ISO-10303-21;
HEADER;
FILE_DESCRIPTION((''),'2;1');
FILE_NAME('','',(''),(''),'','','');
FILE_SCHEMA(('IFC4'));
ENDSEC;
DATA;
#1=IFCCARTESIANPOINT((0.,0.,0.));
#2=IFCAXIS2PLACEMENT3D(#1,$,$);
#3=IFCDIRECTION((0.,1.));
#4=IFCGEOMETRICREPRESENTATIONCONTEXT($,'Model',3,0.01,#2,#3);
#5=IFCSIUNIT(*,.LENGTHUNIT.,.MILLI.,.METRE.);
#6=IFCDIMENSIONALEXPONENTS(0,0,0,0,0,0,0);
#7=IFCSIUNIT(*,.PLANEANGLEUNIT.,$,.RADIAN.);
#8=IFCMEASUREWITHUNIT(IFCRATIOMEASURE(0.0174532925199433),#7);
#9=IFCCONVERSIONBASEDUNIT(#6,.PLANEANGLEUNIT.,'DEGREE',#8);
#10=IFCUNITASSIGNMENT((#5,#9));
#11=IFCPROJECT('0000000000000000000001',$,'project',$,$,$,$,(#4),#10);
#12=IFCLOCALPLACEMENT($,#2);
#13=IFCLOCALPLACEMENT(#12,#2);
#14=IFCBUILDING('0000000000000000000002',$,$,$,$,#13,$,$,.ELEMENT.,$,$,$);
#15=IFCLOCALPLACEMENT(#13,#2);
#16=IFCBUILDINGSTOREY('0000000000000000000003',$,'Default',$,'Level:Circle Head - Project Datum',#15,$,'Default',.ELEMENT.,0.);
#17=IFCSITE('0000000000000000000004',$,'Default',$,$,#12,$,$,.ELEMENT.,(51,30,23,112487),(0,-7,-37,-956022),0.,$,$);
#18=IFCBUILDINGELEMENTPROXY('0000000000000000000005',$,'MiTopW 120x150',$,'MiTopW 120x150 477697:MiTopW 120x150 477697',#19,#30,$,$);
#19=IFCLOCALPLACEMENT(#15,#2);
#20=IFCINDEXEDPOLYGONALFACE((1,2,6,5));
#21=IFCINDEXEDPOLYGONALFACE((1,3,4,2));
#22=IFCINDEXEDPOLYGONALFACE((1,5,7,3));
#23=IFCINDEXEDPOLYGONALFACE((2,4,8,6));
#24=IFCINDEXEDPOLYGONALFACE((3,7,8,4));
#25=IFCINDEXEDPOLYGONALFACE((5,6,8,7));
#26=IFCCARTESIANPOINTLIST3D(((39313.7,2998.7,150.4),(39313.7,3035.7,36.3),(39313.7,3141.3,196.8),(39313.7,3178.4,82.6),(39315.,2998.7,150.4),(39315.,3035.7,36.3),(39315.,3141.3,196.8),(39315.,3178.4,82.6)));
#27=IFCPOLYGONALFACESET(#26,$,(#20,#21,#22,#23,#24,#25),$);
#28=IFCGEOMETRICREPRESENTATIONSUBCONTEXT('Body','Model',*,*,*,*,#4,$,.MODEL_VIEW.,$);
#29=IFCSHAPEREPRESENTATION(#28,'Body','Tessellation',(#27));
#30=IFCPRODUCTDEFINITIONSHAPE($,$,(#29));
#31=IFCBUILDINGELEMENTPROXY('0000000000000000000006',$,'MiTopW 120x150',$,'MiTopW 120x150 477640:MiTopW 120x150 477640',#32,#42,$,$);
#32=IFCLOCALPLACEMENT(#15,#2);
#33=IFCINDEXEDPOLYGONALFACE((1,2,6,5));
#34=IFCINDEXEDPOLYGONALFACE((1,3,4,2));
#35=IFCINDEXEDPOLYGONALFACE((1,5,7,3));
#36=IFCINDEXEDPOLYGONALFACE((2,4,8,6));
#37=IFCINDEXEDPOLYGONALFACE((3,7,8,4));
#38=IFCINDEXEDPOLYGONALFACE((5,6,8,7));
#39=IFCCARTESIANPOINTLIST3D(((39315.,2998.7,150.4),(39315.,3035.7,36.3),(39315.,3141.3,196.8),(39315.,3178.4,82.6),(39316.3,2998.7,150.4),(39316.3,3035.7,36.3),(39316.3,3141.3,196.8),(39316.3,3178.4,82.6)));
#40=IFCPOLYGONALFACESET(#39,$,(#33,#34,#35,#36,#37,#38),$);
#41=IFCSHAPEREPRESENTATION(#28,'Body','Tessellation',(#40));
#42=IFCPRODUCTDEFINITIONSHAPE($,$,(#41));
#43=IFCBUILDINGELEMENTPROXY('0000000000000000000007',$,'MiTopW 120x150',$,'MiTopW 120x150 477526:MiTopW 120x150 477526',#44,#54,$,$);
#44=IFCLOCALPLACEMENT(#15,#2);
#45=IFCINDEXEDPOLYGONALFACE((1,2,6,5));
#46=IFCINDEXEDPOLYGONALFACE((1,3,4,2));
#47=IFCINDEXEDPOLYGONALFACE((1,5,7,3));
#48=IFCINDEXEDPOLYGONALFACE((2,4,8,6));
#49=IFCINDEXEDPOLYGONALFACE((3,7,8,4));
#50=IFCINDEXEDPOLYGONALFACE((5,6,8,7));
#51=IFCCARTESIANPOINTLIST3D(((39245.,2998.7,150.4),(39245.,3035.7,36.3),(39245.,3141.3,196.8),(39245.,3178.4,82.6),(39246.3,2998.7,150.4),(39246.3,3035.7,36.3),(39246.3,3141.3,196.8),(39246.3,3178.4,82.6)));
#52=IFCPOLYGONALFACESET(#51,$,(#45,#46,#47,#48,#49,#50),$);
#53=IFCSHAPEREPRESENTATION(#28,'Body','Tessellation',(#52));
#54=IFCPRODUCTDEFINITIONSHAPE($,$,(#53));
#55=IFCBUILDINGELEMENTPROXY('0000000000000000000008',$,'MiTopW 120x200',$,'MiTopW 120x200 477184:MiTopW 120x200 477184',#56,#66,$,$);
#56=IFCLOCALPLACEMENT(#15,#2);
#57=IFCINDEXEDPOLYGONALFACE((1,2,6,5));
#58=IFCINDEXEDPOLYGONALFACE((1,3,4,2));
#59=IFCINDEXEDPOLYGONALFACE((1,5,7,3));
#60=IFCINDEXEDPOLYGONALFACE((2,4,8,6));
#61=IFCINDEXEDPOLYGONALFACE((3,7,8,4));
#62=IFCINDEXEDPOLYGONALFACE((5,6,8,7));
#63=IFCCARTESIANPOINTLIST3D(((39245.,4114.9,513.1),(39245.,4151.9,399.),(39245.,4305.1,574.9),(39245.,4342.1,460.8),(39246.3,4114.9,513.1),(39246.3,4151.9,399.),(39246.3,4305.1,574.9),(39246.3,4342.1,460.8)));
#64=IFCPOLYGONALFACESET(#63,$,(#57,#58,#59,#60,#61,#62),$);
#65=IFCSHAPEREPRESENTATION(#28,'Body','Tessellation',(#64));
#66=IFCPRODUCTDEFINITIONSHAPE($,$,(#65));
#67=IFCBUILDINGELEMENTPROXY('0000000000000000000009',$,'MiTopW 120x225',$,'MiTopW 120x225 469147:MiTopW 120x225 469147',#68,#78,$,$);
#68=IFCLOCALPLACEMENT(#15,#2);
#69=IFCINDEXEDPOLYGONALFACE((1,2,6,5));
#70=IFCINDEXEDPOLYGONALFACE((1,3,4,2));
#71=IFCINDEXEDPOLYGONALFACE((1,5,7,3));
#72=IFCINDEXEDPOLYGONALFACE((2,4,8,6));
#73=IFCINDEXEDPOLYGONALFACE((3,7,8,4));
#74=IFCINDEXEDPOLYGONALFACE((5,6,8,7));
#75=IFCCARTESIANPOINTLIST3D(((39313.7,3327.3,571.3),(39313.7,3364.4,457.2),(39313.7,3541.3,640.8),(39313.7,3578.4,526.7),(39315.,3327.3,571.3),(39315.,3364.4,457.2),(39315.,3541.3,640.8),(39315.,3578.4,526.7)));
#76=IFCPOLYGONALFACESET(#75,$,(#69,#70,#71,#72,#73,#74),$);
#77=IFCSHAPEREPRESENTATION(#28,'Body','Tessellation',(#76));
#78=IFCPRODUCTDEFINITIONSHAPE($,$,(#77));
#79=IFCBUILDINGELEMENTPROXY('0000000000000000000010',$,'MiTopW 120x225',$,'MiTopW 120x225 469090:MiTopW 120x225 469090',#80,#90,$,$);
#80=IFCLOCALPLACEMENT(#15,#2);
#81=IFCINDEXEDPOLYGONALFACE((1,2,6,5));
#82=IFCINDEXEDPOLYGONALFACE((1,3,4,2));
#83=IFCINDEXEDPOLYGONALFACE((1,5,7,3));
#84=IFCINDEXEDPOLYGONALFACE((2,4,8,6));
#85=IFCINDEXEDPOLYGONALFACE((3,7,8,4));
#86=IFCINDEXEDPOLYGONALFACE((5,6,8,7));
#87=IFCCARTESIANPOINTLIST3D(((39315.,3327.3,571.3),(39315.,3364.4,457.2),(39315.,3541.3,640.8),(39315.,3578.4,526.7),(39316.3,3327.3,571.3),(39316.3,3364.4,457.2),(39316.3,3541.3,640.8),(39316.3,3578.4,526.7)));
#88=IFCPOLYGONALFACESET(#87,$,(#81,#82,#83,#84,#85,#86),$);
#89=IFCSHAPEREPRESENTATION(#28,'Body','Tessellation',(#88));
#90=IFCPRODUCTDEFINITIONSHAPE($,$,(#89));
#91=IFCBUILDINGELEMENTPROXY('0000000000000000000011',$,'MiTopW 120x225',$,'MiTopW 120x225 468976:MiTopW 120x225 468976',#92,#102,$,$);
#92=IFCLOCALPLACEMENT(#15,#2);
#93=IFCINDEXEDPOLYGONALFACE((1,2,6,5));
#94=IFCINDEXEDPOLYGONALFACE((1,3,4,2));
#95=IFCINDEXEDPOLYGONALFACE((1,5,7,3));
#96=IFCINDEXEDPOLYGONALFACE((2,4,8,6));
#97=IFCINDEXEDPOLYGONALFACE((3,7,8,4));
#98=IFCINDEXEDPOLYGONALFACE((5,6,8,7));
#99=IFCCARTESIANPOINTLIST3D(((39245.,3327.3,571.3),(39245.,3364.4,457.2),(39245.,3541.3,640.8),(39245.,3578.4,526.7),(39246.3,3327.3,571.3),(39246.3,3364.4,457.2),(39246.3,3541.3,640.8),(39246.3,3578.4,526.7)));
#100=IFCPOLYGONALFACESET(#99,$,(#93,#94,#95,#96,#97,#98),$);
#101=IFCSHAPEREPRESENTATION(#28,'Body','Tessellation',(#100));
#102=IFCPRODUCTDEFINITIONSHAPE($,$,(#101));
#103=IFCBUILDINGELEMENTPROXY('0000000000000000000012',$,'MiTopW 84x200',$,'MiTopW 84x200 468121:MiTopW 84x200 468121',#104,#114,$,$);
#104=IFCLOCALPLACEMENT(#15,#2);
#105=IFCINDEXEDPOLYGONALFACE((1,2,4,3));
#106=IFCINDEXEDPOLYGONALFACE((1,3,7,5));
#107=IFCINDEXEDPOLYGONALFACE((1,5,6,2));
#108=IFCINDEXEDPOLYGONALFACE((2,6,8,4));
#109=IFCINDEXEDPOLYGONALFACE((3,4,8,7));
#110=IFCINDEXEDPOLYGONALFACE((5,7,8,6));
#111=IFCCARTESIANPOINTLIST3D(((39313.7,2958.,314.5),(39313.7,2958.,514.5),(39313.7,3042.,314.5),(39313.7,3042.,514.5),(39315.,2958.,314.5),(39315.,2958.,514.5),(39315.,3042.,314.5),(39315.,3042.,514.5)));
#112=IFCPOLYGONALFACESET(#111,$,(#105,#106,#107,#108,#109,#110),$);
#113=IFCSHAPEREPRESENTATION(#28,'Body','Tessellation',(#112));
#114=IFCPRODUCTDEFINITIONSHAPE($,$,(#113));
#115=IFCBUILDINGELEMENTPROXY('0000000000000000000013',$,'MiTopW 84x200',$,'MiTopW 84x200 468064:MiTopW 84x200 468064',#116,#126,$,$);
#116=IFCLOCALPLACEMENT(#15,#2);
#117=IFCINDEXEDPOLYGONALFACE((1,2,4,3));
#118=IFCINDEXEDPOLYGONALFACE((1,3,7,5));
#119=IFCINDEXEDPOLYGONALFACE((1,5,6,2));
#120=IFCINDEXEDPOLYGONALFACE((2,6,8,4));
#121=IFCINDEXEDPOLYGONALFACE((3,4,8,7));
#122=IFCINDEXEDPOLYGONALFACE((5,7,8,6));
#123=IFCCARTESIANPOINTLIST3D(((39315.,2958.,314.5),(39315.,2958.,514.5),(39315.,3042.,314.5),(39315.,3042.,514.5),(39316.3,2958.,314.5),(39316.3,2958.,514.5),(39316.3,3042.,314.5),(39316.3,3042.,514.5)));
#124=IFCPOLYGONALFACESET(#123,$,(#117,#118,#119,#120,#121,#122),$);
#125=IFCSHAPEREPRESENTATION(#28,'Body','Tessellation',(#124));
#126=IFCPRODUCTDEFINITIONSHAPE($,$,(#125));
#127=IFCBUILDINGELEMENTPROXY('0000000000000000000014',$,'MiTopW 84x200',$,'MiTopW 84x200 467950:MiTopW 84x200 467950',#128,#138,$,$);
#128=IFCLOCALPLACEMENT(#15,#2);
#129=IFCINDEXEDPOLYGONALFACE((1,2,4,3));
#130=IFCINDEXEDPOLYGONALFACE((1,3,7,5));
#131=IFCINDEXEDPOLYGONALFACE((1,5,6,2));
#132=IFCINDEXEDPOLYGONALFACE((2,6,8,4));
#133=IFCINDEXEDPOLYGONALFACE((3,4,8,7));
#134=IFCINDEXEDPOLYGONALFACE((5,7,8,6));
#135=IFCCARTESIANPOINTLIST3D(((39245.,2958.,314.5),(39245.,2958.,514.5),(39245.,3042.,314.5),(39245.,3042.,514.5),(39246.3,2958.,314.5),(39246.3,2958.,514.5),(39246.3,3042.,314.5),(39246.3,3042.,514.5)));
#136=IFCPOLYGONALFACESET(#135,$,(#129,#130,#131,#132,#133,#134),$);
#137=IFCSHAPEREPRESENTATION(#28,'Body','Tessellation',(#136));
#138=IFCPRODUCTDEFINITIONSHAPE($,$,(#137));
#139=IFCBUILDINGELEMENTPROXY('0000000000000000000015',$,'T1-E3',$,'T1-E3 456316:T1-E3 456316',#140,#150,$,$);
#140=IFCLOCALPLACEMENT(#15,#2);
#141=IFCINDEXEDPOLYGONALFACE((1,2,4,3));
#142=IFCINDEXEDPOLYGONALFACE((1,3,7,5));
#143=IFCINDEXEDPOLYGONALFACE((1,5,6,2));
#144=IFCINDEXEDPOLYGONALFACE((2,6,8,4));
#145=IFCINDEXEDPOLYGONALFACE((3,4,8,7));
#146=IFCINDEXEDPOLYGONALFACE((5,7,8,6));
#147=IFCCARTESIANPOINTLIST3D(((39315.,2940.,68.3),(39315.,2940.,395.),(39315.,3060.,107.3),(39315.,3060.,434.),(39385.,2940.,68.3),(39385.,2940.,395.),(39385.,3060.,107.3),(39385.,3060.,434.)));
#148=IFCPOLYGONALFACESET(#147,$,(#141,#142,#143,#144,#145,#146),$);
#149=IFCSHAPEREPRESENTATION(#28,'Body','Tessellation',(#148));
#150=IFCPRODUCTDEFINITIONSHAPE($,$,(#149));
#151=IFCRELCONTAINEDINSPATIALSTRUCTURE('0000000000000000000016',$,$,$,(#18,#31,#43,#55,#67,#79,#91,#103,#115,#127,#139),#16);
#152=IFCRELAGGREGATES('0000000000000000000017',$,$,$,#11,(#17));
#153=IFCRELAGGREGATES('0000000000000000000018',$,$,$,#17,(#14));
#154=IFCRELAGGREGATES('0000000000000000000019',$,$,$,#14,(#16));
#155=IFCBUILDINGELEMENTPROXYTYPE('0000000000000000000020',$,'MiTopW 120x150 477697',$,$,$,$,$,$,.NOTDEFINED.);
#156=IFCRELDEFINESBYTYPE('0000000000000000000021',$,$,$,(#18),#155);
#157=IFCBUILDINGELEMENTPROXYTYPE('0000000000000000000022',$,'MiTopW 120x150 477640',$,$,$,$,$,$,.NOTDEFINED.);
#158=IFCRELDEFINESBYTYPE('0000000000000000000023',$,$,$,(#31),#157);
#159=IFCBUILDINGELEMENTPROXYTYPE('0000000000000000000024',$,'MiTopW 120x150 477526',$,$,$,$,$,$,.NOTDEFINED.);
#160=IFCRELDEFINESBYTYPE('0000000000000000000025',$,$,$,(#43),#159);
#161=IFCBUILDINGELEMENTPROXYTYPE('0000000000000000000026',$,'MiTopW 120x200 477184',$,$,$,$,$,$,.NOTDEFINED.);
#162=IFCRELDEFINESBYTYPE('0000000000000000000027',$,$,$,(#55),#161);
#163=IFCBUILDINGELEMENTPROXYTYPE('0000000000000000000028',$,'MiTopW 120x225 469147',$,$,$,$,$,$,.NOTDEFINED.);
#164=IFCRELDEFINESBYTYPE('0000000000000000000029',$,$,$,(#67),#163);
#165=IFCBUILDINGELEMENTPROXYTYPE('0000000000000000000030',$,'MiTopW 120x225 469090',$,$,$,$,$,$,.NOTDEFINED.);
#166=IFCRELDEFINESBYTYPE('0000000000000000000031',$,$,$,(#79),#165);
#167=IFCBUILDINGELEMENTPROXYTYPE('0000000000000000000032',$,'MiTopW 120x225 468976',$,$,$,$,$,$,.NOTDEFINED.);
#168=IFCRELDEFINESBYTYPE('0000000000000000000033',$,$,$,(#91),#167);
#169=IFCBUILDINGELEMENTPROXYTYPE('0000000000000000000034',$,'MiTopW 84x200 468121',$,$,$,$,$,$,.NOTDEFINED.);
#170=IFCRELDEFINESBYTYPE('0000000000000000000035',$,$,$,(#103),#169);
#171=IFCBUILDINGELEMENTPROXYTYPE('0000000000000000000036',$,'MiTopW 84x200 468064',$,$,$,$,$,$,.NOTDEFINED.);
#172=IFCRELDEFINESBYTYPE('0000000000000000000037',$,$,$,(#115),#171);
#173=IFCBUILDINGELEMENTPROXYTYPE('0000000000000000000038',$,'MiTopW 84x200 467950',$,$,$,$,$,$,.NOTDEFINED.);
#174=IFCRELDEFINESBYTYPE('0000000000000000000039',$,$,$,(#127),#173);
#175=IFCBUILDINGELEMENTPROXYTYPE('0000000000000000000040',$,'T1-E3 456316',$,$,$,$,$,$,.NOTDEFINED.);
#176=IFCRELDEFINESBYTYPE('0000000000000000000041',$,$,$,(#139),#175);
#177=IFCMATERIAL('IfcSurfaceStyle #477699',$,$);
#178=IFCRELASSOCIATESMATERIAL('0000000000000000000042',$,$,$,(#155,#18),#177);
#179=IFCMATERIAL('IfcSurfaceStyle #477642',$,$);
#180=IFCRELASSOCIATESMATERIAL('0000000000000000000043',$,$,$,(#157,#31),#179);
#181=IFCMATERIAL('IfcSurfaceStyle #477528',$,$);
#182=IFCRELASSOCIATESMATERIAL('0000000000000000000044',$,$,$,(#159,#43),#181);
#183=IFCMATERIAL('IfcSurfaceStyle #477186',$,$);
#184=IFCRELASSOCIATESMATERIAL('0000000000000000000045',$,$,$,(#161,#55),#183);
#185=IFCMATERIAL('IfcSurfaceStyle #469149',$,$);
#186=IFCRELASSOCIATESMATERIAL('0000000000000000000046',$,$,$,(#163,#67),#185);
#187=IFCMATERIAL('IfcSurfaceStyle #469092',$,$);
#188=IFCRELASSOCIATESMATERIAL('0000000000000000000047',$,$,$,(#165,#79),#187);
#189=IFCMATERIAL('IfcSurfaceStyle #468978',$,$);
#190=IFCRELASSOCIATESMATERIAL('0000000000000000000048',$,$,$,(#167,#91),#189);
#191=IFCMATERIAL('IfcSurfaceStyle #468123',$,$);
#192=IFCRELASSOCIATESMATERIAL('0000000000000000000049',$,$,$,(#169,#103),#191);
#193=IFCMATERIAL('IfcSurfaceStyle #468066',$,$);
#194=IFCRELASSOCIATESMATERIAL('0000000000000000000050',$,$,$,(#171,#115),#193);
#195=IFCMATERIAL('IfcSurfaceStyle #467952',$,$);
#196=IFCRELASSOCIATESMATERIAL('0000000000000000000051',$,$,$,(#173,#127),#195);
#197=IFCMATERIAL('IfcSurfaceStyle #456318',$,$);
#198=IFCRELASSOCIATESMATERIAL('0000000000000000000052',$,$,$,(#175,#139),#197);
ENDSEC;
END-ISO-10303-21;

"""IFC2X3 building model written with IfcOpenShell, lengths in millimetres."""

from ifc_helpers import new_model, entity, si_unit, converted_unit, direction, frame, frame_2d, origin, place, context, subcontext, project, spatial, polyline, rectangle, outline, extrude, source, transform, mapped, material, type_object, type_shapes, element, save


model = new_model("IFC2X3")

# Units and contexts
model_context = context("Model", 3, precision=0.01, world=origin(), true_north=direction((0.0, 1.0)))
body_context = subcontext(model_context, "Body", "Model", "MODEL_VIEW")
ifc_project = project(units=[si_unit("LENGTHUNIT", "METRE", prefix="MILLI"), converted_unit("PLANEANGLEUNIT", "DEGREE", entity("IfcRatioMeasure", 0.0174532925199433), si_unit("PLANEANGLEUNIT", "RADIAN"), dimensions=[0, 0, 0, 0, 0, 0, 0])], contexts=[model_context])

# Site, building, storey
site_placement = place(None, origin())
site = spatial("IfcSite", under=ifc_project, at=site_placement, Name="Default", CompositionType="ELEMENT", RefLatitude=(51, 30, 23, 112487), RefLongitude=(0, -7, -37, -956022), RefElevation=0.0)
building_placement = place(site_placement, origin())
building = spatial("IfcBuilding", under=site, at=building_placement, CompositionType="ELEMENT")
storey_placement = place(building_placement, origin())
storey = spatial("IfcBuildingStorey", under=building, at=storey_placement, Name="Default", ObjectType="Level:Circle Head - Project Datum", LongName="Default", CompositionType="ELEMENT", Elevation=0.0)

# Building element proxies
ifc_material_1 = material(Name="IfcSurfaceStyle #477699")
building_element_proxy_type_1 = type_object("IfcBuildingElementProxyType", Name="MiTopW 120x150 477697", PredefinedType="NOTDEFINED", material=ifc_material_1)
shared_shape_1 = source(origin(), body_context, "Body", "SweptSolid", [
    extrude(outline(polyline([(-75.0, -60.0), (75.0, -60.0), (75.0, 60.0), (-75.0, 60.0), (-75.0, -60.0)])), frame((75.0, 60.0, 0.0), z_axis=(0.0, 0.0, 1.0), x_axis=(-1.0, 0.0, 0.0)), (0.0, 0.0, 1.0), 1.3),
])
type_shapes(building_element_proxy_type_1, [shared_shape_1])
proxy_1_placement = place(building_placement, frame((39315.0, 2998.7, 150.4), z_axis=(-1.0, 0.0, 0.0), x_axis=(0.0, 0.951057, 0.309017)))
element("IfcBuildingElementProxy", 1, at=proxy_1_placement, inside=storey, type_object=building_element_proxy_type_1, material=ifc_material_1, Name="MiTopW 120x150", ObjectType="MiTopW 120x150 477697:MiTopW 120x150 477697", context=body_context, shape_type="MappedRepresentation", body=[
    mapped(shared_shape_1, transform((0.0, 0.0, 0.0), scale=1.0)),
])
ifc_material_2 = material(Name="IfcSurfaceStyle #477642")
building_element_proxy_type_2 = type_object("IfcBuildingElementProxyType", Name="MiTopW 120x150 477640", PredefinedType="NOTDEFINED", material=ifc_material_2)
shared_shape_2 = source(origin(), body_context, "Body", "SweptSolid", [
    extrude(outline(polyline([(-75.0, -60.0), (75.0, -60.0), (75.0, 60.0), (-75.0, 60.0), (-75.0, -60.0)])), frame((75.0, 60.0, 0.0), z_axis=(0.0, 0.0, 1.0), x_axis=(-1.0, 0.0, 0.0)), (0.0, 0.0, 1.0), 1.3),
])
type_shapes(building_element_proxy_type_2, [shared_shape_2])
proxy_2_placement = place(building_placement, frame((39316.3, 2998.7, 150.4), z_axis=(-1.0, 0.0, 0.0), x_axis=(0.0, 0.951057, 0.309017)))
element("IfcBuildingElementProxy", 2, at=proxy_2_placement, inside=storey, type_object=building_element_proxy_type_2, material=ifc_material_2, Name="MiTopW 120x150", ObjectType="MiTopW 120x150 477640:MiTopW 120x150 477640", context=body_context, shape_type="MappedRepresentation", body=[
    mapped(shared_shape_2, transform((0.0, 0.0, 0.0), scale=1.0)),
])
ifc_material_3 = material(Name="IfcSurfaceStyle #477528")
building_element_proxy_type_3 = type_object("IfcBuildingElementProxyType", Name="MiTopW 120x150 477526", PredefinedType="NOTDEFINED", material=ifc_material_3)
shared_shape_3 = source(origin(), body_context, "Body", "SweptSolid", [
    extrude(outline(polyline([(-75.0, -60.0), (75.0, -60.0), (75.0, 60.0), (-75.0, 60.0), (-75.0, -60.0)])), frame((75.0, 60.0, 0.0), z_axis=(0.0, 0.0, 1.0), x_axis=(-1.0, 0.0, 0.0)), (0.0, 0.0, 1.0), 1.3),
])
type_shapes(building_element_proxy_type_3, [shared_shape_3])
proxy_3_placement = place(building_placement, frame((39246.3, 2998.7, 150.4), z_axis=(-1.0, 0.0, 0.0), x_axis=(0.0, 0.951057, 0.309017)))
element("IfcBuildingElementProxy", 3, at=proxy_3_placement, inside=storey, type_object=building_element_proxy_type_3, material=ifc_material_3, Name="MiTopW 120x150", ObjectType="MiTopW 120x150 477526:MiTopW 120x150 477526", context=body_context, shape_type="MappedRepresentation", body=[
    mapped(shared_shape_3, transform((0.0, 0.0, 0.0), scale=1.0)),
])
ifc_material_4 = material(Name="IfcSurfaceStyle #477186")
building_element_proxy_type_4 = type_object("IfcBuildingElementProxyType", Name="MiTopW 120x200 477184", PredefinedType="NOTDEFINED", material=ifc_material_4)
shared_shape_4 = source(origin(), body_context, "Body", "SweptSolid", [
    extrude(outline(polyline([(-100.0, -60.0), (100.0, -60.0), (100.0, 60.0), (-100.0, 60.0), (-100.0, -60.0)])), frame((100.0, 60.0, 0.0), z_axis=(0.0, 0.0, 1.0), x_axis=(-1.0, 0.0, 0.0)), (0.0, 0.0, 1.0), 1.3),
])
type_shapes(building_element_proxy_type_4, [shared_shape_4])
proxy_4_placement = place(building_placement, frame((39246.3, 4114.9, 513.1), z_axis=(-1.0, 0.0, 0.0), x_axis=(0.0, 0.951057, 0.309017)))
element("IfcBuildingElementProxy", 4, at=proxy_4_placement, inside=storey, type_object=building_element_proxy_type_4, material=ifc_material_4, Name="MiTopW 120x200", ObjectType="MiTopW 120x200 477184:MiTopW 120x200 477184", context=body_context, shape_type="MappedRepresentation", body=[
    mapped(shared_shape_4, transform((0.0, 0.0, 0.0), scale=1.0)),
])
ifc_material_5 = material(Name="IfcSurfaceStyle #469149")
building_element_proxy_type_5 = type_object("IfcBuildingElementProxyType", Name="MiTopW 120x225 469147", PredefinedType="NOTDEFINED", material=ifc_material_5)
shared_shape_5 = source(origin(), body_context, "Body", "SweptSolid", [
    extrude(outline(polyline([(-112.5, -60.0), (112.5, -60.0), (112.5, 60.0), (-112.5, 60.0), (-112.5, -60.0)])), frame((112.5, 60.0, 0.0), z_axis=(0.0, 0.0, 1.0), x_axis=(-1.0, 0.0, 0.0)), (0.0, 0.0, 1.0), 1.3),
])
type_shapes(building_element_proxy_type_5, [shared_shape_5])
proxy_5_placement = place(building_placement, frame((39315.0, 3327.3, 571.3), z_axis=(-1.0, 0.0, 0.0), x_axis=(0.0, 0.951057, 0.309017)))
element("IfcBuildingElementProxy", 5, at=proxy_5_placement, inside=storey, type_object=building_element_proxy_type_5, material=ifc_material_5, Name="MiTopW 120x225", ObjectType="MiTopW 120x225 469147:MiTopW 120x225 469147", context=body_context, shape_type="MappedRepresentation", body=[
    mapped(shared_shape_5, transform((0.0, 0.0, 0.0), scale=1.0)),
])
ifc_material_6 = material(Name="IfcSurfaceStyle #469092")
building_element_proxy_type_6 = type_object("IfcBuildingElementProxyType", Name="MiTopW 120x225 469090", PredefinedType="NOTDEFINED", material=ifc_material_6)
shared_shape_6 = source(origin(), body_context, "Body", "SweptSolid", [
    extrude(outline(polyline([(-112.5, -60.0), (112.5, -60.0), (112.5, 60.0), (-112.5, 60.0), (-112.5, -60.0)])), frame((112.5, 60.0, 0.0), z_axis=(0.0, 0.0, 1.0), x_axis=(-1.0, 0.0, 0.0)), (0.0, 0.0, 1.0), 1.3),
])
type_shapes(building_element_proxy_type_6, [shared_shape_6])
proxy_6_placement = place(building_placement, frame((39316.3, 3327.3, 571.3), z_axis=(-1.0, 0.0, 0.0), x_axis=(0.0, 0.951057, 0.309017)))
element("IfcBuildingElementProxy", 6, at=proxy_6_placement, inside=storey, type_object=building_element_proxy_type_6, material=ifc_material_6, Name="MiTopW 120x225", ObjectType="MiTopW 120x225 469090:MiTopW 120x225 469090", context=body_context, shape_type="MappedRepresentation", body=[
    mapped(shared_shape_6, transform((0.0, 0.0, 0.0), scale=1.0)),
])
ifc_material_7 = material(Name="IfcSurfaceStyle #468978")
building_element_proxy_type_7 = type_object("IfcBuildingElementProxyType", Name="MiTopW 120x225 468976", PredefinedType="NOTDEFINED", material=ifc_material_7)
shared_shape_7 = source(origin(), body_context, "Body", "SweptSolid", [
    extrude(outline(polyline([(-112.5, -60.0), (112.5, -60.0), (112.5, 60.0), (-112.5, 60.0), (-112.5, -60.0)])), frame((112.5, 60.0, 0.0), z_axis=(0.0, 0.0, 1.0), x_axis=(-1.0, 0.0, 0.0)), (0.0, 0.0, 1.0), 1.3),
])
type_shapes(building_element_proxy_type_7, [shared_shape_7])
proxy_7_placement = place(building_placement, frame((39246.3, 3327.3, 571.3), z_axis=(-1.0, 0.0, 0.0), x_axis=(0.0, 0.951057, 0.309017)))
element("IfcBuildingElementProxy", 7, at=proxy_7_placement, inside=storey, type_object=building_element_proxy_type_7, material=ifc_material_7, Name="MiTopW 120x225", ObjectType="MiTopW 120x225 468976:MiTopW 120x225 468976", context=body_context, shape_type="MappedRepresentation", body=[
    mapped(shared_shape_7, transform((0.0, 0.0, 0.0), scale=1.0)),
])
ifc_material_8 = material(Name="IfcSurfaceStyle #468123")
building_element_proxy_type_8 = type_object("IfcBuildingElementProxyType", Name="MiTopW 84x200 468121", PredefinedType="NOTDEFINED", material=ifc_material_8)
shared_shape_8 = source(origin(), body_context, "Body", "SweptSolid", [
    extrude(rectangle(XDim=200.0, YDim=84.0, at=frame_2d((0.0, 0.0), x_axis=(1.0, 0.0))), frame((100.0, 42.0, 0.0), z_axis=(0.0, 0.0, 1.0), x_axis=(-1.0, 0.0, 0.0)), (0.0, 0.0, 1.0), 1.3),
])
type_shapes(building_element_proxy_type_8, [shared_shape_8])
proxy_8_placement = place(building_placement, frame((39315.0, 3042.0, 514.5), z_axis=(-1.0, 0.0, 0.0), x_axis=(0.0, 0.0, -1.0)))
element("IfcBuildingElementProxy", 8, at=proxy_8_placement, inside=storey, type_object=building_element_proxy_type_8, material=ifc_material_8, Name="MiTopW 84x200", ObjectType="MiTopW 84x200 468121:MiTopW 84x200 468121", context=body_context, shape_type="MappedRepresentation", body=[
    mapped(shared_shape_8, transform((0.0, 0.0, 0.0), scale=1.0)),
])
ifc_material_9 = material(Name="IfcSurfaceStyle #468066")
building_element_proxy_type_9 = type_object("IfcBuildingElementProxyType", Name="MiTopW 84x200 468064", PredefinedType="NOTDEFINED", material=ifc_material_9)
shared_shape_9 = source(origin(), body_context, "Body", "SweptSolid", [
    extrude(rectangle(XDim=200.0, YDim=84.0, at=frame_2d((0.0, 0.0), x_axis=(1.0, 0.0))), frame((100.0, 42.0, 0.0), z_axis=(0.0, 0.0, 1.0), x_axis=(-1.0, 0.0, 0.0)), (0.0, 0.0, 1.0), 1.3),
])
type_shapes(building_element_proxy_type_9, [shared_shape_9])
proxy_9_placement = place(building_placement, frame((39316.3, 3042.0, 514.5), z_axis=(-1.0, 0.0, 0.0), x_axis=(0.0, 0.0, -1.0)))
element("IfcBuildingElementProxy", 9, at=proxy_9_placement, inside=storey, type_object=building_element_proxy_type_9, material=ifc_material_9, Name="MiTopW 84x200", ObjectType="MiTopW 84x200 468064:MiTopW 84x200 468064", context=body_context, shape_type="MappedRepresentation", body=[
    mapped(shared_shape_9, transform((0.0, 0.0, 0.0), scale=1.0)),
])
ifc_material_10 = material(Name="IfcSurfaceStyle #467952")
building_element_proxy_type_10 = type_object("IfcBuildingElementProxyType", Name="MiTopW 84x200 467950", PredefinedType="NOTDEFINED", material=ifc_material_10)
shared_shape_10 = source(origin(), body_context, "Body", "SweptSolid", [
    extrude(rectangle(XDim=200.0, YDim=84.0, at=frame_2d((0.0, 0.0), x_axis=(1.0, 0.0))), frame((100.0, 42.0, 0.0), z_axis=(0.0, 0.0, 1.0), x_axis=(-1.0, 0.0, 0.0)), (0.0, 0.0, 1.0), 1.3),
])
type_shapes(building_element_proxy_type_10, [shared_shape_10])
proxy_10_placement = place(building_placement, frame((39246.3, 3042.0, 514.5), z_axis=(-1.0, 0.0, 0.0), x_axis=(0.0, 0.0, -1.0)))
element("IfcBuildingElementProxy", 10, at=proxy_10_placement, inside=storey, type_object=building_element_proxy_type_10, material=ifc_material_10, Name="MiTopW 84x200", ObjectType="MiTopW 84x200 467950:MiTopW 84x200 467950", context=body_context, shape_type="MappedRepresentation", body=[
    mapped(shared_shape_10, transform((0.0, 0.0, 0.0), scale=1.0)),
])
ifc_material_11 = material(Name="IfcSurfaceStyle #456318")
building_element_proxy_type_11 = type_object("IfcBuildingElementProxyType", Name="T1-E3 456316", PredefinedType="NOTDEFINED", material=ifc_material_11)
shared_shape_11 = source(origin(), body_context, "Body", "SweptSolid", [
    extrude(outline(polyline([(-182.8, -60.0), (143.8, -60.0), (182.8, 60.0), (-143.8, 60.0), (-182.8, -60.0)])), frame((182.8, 60.0, 0.0), z_axis=(0.0, 0.0, 1.0), x_axis=(-1.0, 0.0, 0.0)), (0.0, 0.0, 1.0), 70.0),
])
type_shapes(building_element_proxy_type_11, [shared_shape_11])
proxy_11_placement = place(building_placement, frame((39385.0, 2940.0, 68.3), z_axis=(-1.0, 0.0, 0.0), x_axis=(0.0, 0.0, 1.0)))
element("IfcBuildingElementProxy", 11, at=proxy_11_placement, inside=storey, type_object=building_element_proxy_type_11, material=ifc_material_11, Name="T1-E3", ObjectType="T1-E3 456316:T1-E3 456316", context=body_context, shape_type="MappedRepresentation", body=[
    mapped(shared_shape_11, transform((0.0, 0.0, 0.0), scale=1.0)),
])

save(model, "model.ifc")
